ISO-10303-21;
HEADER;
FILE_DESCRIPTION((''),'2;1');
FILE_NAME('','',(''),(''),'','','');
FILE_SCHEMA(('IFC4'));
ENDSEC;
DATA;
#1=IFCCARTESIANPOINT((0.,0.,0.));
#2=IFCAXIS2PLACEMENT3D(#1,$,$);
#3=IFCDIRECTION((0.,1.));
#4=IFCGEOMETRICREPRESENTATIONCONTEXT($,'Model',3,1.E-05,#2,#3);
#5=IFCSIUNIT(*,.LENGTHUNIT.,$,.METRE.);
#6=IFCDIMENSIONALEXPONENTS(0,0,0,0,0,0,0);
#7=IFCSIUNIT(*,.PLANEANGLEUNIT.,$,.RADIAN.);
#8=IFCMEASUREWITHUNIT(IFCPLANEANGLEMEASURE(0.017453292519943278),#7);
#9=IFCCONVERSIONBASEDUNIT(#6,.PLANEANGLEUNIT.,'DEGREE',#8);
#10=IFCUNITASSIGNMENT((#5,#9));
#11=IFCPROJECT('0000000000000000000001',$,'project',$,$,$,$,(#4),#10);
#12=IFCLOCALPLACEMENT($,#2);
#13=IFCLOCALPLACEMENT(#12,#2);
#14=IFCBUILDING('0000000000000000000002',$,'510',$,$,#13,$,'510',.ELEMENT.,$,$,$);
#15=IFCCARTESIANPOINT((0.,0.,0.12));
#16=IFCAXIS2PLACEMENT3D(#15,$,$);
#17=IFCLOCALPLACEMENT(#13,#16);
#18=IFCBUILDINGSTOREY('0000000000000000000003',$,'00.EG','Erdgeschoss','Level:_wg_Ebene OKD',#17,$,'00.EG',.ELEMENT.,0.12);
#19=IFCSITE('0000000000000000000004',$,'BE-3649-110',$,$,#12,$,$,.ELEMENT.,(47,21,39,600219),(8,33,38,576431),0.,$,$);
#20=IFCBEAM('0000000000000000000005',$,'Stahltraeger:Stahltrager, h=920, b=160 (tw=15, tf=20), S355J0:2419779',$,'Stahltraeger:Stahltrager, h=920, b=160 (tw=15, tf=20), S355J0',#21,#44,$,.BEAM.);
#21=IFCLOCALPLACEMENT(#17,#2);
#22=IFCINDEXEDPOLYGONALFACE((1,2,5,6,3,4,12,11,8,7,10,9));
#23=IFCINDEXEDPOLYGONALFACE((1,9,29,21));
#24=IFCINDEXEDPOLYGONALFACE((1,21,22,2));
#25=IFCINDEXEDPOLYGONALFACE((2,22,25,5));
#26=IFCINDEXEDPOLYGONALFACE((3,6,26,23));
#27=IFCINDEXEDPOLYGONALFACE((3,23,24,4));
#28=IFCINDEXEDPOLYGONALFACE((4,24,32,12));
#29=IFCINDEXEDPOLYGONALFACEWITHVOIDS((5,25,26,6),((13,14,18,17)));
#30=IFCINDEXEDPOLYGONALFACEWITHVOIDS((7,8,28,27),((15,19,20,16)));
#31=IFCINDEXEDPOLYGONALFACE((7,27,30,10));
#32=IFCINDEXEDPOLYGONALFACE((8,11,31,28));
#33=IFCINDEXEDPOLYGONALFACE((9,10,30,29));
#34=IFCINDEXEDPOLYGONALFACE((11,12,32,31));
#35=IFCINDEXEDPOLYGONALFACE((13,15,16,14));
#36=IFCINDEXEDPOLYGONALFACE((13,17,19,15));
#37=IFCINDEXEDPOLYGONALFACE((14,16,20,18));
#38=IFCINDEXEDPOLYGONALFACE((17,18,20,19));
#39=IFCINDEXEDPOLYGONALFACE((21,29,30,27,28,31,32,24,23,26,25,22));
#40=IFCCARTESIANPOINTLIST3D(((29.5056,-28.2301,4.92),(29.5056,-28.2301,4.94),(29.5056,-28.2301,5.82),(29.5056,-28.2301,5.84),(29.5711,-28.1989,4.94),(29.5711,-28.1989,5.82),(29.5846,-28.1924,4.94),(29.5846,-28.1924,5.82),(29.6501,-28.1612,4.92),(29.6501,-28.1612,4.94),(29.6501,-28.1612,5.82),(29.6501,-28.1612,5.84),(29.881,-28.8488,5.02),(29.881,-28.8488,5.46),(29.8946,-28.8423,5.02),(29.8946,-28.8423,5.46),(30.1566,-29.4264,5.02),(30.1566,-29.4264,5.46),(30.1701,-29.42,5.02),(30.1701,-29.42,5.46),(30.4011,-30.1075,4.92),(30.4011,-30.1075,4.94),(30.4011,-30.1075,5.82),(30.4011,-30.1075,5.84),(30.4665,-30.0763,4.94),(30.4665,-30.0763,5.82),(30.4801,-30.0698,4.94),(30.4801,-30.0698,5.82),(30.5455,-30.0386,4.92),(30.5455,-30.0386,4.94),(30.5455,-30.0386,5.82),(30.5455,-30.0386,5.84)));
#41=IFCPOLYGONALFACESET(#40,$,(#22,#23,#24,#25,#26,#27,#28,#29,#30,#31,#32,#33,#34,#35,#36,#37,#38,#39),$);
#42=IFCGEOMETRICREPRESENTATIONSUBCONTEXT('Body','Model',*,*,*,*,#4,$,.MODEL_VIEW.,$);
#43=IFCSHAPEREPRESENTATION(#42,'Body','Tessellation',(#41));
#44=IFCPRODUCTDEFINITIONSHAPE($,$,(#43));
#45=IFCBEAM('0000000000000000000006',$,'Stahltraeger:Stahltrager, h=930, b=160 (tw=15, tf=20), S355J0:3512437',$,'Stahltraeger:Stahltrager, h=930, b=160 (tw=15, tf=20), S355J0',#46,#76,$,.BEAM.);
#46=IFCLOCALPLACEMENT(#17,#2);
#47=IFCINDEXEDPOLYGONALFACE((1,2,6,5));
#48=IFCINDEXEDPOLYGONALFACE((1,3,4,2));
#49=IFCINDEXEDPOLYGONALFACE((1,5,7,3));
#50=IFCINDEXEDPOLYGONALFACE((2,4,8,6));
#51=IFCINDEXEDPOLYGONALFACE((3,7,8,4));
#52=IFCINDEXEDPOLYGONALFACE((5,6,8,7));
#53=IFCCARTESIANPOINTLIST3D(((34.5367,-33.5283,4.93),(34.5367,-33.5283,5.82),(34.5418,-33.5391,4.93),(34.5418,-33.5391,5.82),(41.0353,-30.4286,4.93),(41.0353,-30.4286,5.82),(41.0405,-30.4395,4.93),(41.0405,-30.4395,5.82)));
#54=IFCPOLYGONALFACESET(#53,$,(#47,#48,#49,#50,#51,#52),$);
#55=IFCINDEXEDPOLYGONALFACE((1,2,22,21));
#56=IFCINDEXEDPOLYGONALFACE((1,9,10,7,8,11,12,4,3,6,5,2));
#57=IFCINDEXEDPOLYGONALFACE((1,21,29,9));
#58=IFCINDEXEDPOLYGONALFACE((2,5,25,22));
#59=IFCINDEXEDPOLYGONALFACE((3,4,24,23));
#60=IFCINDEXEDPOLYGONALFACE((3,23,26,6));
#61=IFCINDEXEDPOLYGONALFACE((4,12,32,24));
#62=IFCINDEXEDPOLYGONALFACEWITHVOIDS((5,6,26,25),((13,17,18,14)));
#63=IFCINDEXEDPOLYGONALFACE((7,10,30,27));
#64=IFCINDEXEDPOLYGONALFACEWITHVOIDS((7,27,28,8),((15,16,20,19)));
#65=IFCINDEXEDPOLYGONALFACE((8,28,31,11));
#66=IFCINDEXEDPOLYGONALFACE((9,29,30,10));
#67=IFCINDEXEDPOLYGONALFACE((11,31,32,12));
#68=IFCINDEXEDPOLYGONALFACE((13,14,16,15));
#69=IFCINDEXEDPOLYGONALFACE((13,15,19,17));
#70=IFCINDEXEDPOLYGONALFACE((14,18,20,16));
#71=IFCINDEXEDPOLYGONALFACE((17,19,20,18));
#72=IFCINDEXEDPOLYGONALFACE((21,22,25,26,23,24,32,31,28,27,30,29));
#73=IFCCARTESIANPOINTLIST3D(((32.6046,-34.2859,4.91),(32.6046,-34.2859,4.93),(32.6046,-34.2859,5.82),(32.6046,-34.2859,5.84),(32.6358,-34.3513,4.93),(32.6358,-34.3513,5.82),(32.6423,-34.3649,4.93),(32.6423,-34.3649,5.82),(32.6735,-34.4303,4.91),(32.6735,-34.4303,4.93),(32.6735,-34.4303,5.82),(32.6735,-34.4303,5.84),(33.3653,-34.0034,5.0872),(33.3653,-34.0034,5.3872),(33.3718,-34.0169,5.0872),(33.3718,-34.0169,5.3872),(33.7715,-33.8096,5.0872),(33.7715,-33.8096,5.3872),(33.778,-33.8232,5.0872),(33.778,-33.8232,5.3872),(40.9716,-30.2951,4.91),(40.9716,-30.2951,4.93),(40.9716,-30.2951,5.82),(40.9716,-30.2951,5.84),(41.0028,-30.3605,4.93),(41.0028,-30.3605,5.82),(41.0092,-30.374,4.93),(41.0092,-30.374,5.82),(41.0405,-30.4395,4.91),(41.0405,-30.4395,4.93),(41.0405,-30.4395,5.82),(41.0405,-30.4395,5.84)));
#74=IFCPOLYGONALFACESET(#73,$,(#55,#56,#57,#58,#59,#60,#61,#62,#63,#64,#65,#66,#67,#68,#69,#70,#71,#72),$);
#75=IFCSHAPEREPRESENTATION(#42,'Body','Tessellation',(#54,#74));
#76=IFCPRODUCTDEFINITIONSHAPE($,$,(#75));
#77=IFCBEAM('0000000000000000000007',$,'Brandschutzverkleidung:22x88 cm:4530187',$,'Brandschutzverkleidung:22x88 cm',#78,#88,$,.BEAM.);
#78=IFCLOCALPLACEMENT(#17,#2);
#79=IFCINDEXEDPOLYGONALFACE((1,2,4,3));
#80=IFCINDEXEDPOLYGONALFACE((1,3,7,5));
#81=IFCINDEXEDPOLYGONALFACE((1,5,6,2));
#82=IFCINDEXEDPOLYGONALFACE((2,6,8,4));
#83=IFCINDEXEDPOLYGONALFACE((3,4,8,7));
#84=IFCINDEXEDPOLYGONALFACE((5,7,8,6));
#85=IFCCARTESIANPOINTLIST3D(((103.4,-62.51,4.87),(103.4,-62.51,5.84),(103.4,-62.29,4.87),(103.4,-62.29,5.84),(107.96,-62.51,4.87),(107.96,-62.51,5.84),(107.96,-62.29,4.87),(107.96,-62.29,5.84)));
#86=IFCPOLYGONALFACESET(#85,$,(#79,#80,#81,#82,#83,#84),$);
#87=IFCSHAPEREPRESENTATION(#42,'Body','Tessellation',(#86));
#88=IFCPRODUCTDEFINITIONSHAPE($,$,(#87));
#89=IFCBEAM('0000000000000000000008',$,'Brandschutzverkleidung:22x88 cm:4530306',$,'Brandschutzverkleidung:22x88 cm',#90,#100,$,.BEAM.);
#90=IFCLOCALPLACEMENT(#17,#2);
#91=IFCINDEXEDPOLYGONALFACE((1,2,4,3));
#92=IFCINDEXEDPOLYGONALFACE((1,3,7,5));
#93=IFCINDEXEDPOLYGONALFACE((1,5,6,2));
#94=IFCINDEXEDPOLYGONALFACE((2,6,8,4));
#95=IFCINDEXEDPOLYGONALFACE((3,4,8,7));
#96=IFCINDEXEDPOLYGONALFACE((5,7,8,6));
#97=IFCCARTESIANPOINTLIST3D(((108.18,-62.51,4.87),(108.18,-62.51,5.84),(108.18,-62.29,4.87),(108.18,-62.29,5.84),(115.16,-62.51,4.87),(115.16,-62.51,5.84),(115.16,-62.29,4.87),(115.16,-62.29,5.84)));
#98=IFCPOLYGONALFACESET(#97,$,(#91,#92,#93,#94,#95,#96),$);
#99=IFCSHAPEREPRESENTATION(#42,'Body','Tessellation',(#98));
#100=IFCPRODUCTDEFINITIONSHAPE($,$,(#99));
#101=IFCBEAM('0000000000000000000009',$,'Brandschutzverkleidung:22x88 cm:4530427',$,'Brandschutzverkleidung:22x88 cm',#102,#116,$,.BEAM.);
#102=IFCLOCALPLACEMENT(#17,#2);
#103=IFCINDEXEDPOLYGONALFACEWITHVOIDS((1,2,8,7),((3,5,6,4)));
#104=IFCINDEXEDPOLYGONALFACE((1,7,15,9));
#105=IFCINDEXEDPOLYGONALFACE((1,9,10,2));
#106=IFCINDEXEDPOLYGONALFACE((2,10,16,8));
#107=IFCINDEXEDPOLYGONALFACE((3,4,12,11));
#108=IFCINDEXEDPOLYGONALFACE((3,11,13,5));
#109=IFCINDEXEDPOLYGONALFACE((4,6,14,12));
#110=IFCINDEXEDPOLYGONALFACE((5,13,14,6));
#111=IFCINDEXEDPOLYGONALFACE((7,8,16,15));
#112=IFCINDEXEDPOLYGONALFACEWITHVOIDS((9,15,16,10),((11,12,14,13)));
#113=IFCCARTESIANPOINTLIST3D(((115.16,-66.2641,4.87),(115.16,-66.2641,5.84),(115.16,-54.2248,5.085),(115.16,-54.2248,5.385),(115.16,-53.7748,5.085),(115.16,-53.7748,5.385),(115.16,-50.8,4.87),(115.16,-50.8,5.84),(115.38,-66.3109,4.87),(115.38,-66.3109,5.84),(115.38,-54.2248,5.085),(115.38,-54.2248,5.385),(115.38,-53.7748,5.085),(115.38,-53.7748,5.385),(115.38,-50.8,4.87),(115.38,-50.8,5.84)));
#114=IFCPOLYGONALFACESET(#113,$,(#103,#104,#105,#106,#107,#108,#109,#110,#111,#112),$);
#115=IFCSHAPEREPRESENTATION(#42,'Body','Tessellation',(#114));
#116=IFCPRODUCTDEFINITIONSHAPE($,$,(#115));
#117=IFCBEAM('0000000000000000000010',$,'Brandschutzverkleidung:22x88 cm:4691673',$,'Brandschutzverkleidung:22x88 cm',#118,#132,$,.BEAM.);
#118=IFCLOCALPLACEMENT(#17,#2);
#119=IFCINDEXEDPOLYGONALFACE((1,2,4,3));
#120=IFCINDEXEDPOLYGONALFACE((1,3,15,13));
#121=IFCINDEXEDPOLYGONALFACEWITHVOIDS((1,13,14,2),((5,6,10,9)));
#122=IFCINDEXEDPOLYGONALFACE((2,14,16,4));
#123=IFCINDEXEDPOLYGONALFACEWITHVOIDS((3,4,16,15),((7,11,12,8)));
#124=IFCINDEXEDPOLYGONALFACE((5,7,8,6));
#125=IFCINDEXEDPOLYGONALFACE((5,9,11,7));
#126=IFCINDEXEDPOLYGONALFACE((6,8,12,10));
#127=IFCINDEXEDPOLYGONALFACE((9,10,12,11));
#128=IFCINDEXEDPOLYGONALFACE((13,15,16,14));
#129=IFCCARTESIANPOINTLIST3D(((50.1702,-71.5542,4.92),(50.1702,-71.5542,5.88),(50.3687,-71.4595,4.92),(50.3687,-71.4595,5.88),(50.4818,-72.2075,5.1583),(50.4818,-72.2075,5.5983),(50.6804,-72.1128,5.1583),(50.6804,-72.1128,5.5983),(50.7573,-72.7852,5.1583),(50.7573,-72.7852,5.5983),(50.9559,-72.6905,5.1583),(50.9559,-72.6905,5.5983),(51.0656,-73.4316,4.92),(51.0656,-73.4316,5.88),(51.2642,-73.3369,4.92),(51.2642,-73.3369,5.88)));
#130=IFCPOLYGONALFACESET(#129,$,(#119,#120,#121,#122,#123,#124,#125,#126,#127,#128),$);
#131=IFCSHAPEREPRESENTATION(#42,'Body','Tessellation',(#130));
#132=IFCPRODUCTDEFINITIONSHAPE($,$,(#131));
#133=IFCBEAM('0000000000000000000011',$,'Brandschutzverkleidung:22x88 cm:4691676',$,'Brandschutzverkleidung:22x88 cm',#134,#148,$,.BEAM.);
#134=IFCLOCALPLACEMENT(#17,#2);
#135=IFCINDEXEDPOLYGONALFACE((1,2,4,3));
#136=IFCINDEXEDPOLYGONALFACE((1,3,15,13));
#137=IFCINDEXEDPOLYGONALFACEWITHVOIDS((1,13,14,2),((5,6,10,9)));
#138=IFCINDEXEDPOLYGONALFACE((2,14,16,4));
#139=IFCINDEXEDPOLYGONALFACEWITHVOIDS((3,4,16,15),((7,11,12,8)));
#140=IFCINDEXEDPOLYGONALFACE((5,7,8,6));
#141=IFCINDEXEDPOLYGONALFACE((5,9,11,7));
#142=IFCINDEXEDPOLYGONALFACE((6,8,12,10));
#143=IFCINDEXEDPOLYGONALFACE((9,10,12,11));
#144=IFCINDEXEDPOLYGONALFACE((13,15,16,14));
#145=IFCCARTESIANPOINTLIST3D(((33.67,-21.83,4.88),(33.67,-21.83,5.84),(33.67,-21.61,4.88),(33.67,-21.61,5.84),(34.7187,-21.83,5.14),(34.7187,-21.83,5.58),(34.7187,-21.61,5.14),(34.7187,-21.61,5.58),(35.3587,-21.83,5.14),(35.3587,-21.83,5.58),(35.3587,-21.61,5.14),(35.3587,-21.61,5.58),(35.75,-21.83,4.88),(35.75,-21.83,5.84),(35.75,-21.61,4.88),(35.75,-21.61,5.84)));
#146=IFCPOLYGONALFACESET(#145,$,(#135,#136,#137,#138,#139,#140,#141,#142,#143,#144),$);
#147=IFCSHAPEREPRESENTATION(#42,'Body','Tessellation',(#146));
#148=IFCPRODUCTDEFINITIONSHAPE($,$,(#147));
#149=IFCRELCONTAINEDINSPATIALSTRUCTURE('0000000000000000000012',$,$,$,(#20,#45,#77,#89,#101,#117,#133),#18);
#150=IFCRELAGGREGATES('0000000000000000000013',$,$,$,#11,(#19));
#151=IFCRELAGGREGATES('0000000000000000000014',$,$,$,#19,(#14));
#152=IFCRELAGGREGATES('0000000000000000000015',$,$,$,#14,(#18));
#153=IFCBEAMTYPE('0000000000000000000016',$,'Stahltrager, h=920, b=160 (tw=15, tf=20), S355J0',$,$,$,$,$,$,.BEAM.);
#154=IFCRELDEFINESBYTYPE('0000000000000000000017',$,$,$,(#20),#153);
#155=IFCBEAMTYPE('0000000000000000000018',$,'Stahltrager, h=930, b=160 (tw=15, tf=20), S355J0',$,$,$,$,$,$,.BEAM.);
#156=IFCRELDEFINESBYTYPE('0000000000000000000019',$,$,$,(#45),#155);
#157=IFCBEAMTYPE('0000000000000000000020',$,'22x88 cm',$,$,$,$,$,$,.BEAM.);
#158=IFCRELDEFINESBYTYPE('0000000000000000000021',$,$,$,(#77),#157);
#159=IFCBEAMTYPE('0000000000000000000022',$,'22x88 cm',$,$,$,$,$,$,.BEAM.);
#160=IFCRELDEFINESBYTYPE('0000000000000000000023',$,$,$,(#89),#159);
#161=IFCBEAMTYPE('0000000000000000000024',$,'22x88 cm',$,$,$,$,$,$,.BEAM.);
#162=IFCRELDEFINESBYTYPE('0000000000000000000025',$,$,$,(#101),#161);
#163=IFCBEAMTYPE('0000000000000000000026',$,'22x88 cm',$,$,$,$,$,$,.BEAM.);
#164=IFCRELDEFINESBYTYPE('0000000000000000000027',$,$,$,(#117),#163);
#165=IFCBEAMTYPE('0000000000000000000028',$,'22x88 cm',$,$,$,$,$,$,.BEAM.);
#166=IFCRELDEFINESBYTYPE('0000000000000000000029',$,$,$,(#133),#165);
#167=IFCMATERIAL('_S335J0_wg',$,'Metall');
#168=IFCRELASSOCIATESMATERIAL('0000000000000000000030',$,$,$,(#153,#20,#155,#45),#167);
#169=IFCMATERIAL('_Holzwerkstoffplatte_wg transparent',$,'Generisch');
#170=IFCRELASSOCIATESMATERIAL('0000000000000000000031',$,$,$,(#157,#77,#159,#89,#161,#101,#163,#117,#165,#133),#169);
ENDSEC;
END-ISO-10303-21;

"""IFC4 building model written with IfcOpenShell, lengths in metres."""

from ifc_helpers import new_model, entity, si_unit, converted_unit, direction, frame, origin, place, context, subcontext, project, spatial, indexed_curve, outline, extrude, source, transform, mapped, material, type_object, type_shapes, element, save


model = new_model("IFC4")

# Units and contexts
model_context = context("Model", 3, precision=1e-05, world=origin(), true_north=direction((0.0, 1.0)))
body_context = subcontext(model_context, "Body", "Model", "MODEL_VIEW")
ifc_project = project(units=[si_unit("LENGTHUNIT", "METRE"), converted_unit("PLANEANGLEUNIT", "DEGREE", entity("IfcPlaneAngleMeasure", 0.017453292519943278), si_unit("PLANEANGLEUNIT", "RADIAN"), dimensions=[0, 0, 0, 0, 0, 0, 0])], contexts=[model_context])

# Site, building, storey
site_placement = place(None, origin())
site = spatial("IfcSite", under=ifc_project, at=site_placement, Name="BE-3649-110", CompositionType="ELEMENT", RefLatitude=(47, 21, 39, 600219), RefLongitude=(8, 33, 38, 576431), RefElevation=0.0)
building_placement = place(site_placement, origin())
building = spatial("IfcBuilding", under=site, at=building_placement, Name="510", LongName="510", CompositionType="ELEMENT")
storey_placement = place(building_placement, frame((0.0, 0.0, 0.12)))
storey = spatial("IfcBuildingStorey", under=building, at=storey_placement, Name="00.EG", Description="Erdgeschoss", ObjectType="Level:_wg_Ebene OKD", LongName="00.EG", CompositionType="ELEMENT", Elevation=0.12)

# Beams, openings
ifc_material_1 = material(Name="_S335J0_wg", Category="Metall")
beam_type_1 = type_object("IfcBeamType", Name="Stahltrager, h=920, b=160 (tw=15, tf=20), S355J0", PredefinedType="BEAM", material=ifc_material_1)
shared_shape_1 = source(origin(), body_context, "Body", "SweptSolid", [
    extrude(outline(indexed_curve([(-0.08, -0.44), (-0.08, -0.46), (0.08, -0.46), (0.08, -0.44), (0.0075, -0.44), (0.0075, 0.44), (0.08, 0.44), (0.08, 0.46), (-0.08, 0.46), (-0.08, 0.44), (-0.0075, 0.44), (-0.0075, -0.44), (-0.08, -0.44)], self_intersect=False)), frame((0.9677, 0.0344, 0.46), z_axis=(0.430511, -0.902585, 0.0), x_axis=(0.902585, 0.430511, 0.0)), (0.0, 0.0, -1.0), 2.08),
])
type_shapes(beam_type_1, [shared_shape_1])
beam_1_placement = place(storey_placement, frame((29.5056, -30.1075, 4.92)))
beam_1 = element("IfcBeam", 1, at=beam_1_placement, inside=storey, type_object=beam_type_1, material=ifc_material_1, Name="Stahltraeger:Stahltrager, h=920, b=160 (tw=15, tf=20), S355J0:2419779", ObjectType="Stahltraeger:Stahltrager, h=920, b=160 (tw=15, tf=20), S355J0", PredefinedType="BEAM", context=body_context, shape_type="MappedRepresentation", body=[
    mapped(shared_shape_1, transform((0.0, 0.0, 0.0), scale=1.0)),
])
opening_1_placement = place(storey_placement, frame((29.5056, -30.1075, 4.92)))
element("IfcOpeningElement", 2, at=opening_1_placement, cuts=beam_1, PredefinedType="OPENING", context=body_context, shape_type="SweptSolid", body=[
    extrude(outline(indexed_curve([(-0.32, -0.22), (0.32, -0.22), (0.32, 0.22), (-0.32, 0.22), (-0.32, -0.22)], self_intersect=False)), frame((0.5267, 0.9764, 0.32), z_axis=(-0.902585, -0.430511, 0.0), x_axis=(0.430511, -0.902585, 0.0)), (0.0, 0.0, 1.0), 0.015),
])
beam_type_2 = type_object("IfcBeamType", Name="Stahltrager, h=930, b=160 (tw=15, tf=20), S355J0", PredefinedType="BEAM", material=ifc_material_1)
shared_shape_2 = source(origin(), body_context, "Body", "SweptSolid", [
    extrude(outline(indexed_curve([(-0.006, -0.445), (0.006, -0.445), (0.006, 0.445), (-0.006, 0.445), (-0.006, -0.445)], self_intersect=False)), frame((1.9347, 0.8966, 0.465), z_axis=(0.902585, 0.430511, 0.0), x_axis=(0.430511, -0.902585, 0.0)), (0.0, 0.0, 1.0), 7.2),
    extrude(outline(indexed_curve([(-0.08, -0.445), (-0.08, -0.465), (0.08, -0.465), (0.08, -0.445), (0.0075, -0.445), (0.0075, 0.445), (0.08, 0.445), (0.08, 0.465), (-0.08, 0.465), (-0.08, 0.445), (-0.0075, 0.445), (-0.0075, -0.445), (-0.08, -0.445)], self_intersect=False)), frame((0.0344, 0.0722, 0.465), z_axis=(-0.902585, -0.430511, 0.0), x_axis=(0.430511, -0.902585, 0.0)), (0.0, 0.0, -1.0), 9.27),
])
type_shapes(beam_type_2, [shared_shape_2])
beam_2_placement = place(storey_placement, frame((32.6046, -34.4303, 4.91)))
beam_2 = element("IfcBeam", 3, at=beam_2_placement, inside=storey, type_object=beam_type_2, material=ifc_material_1, Name="Stahltraeger:Stahltrager, h=930, b=160 (tw=15, tf=20), S355J0:3512437", ObjectType="Stahltraeger:Stahltrager, h=930, b=160 (tw=15, tf=20), S355J0", PredefinedType="BEAM", context=body_context, shape_type="MappedRepresentation", body=[
    mapped(shared_shape_2, transform((0.0, 0.0, 0.0), scale=1.0)),
])
opening_2_placement = place(storey_placement, frame((32.6046, -34.4303, 4.91)))
element("IfcOpeningElement", 4, at=opening_2_placement, cuts=beam_2, PredefinedType="OPENING", context=body_context, shape_type="SweptSolid", body=[
    extrude(outline(indexed_curve([(-0.225, -0.15), (0.225, -0.15), (0.225, 0.15), (-0.225, 0.15), (-0.225, -0.15)], self_intersect=False)), frame((0.9638, 0.5238, 0.3272), z_axis=(0.430511, -0.902585, 0.0), x_axis=(0.902585, 0.430511, 0.0)), (0.0, 0.0, 1.0), 0.015),
])

# Beams
ifc_material_2 = material(Name="_Holzwerkstoffplatte_wg transparent", Category="Generisch")
beam_type_3 = type_object("IfcBeamType", Name="22x88 cm", PredefinedType="BEAM", material=ifc_material_2)
shared_shape_3 = source(origin(), body_context, "Body", "SweptSolid", [
    extrude(outline(indexed_curve([(-2.28, -0.11), (2.28, -0.11), (2.28, 0.11), (-2.28, 0.11), (-2.28, -0.11)], self_intersect=False)), frame((105.68, -62.4, -0.485)), (0.0, 0.0, 1.0), 0.97),
])
type_shapes(beam_type_3, [shared_shape_3])
beam_3_placement = place(storey_placement, frame((0.0, 0.0, 5.355)))
element("IfcBeam", 5, at=beam_3_placement, inside=storey, type_object=beam_type_3, material=ifc_material_2, Name="Brandschutzverkleidung:22x88 cm:4530187", ObjectType="Brandschutzverkleidung:22x88 cm", PredefinedType="BEAM", context=body_context, shape_type="MappedRepresentation", body=[
    mapped(shared_shape_3, transform((0.0, 0.0, 0.0), scale=1.0)),
])
beam_type_4 = type_object("IfcBeamType", Name="22x88 cm", PredefinedType="BEAM", material=ifc_material_2)
shared_shape_4 = source(origin(), body_context, "Body", "SweptSolid", [
    extrude(outline(indexed_curve([(-3.49, -0.11), (3.49, -0.11), (3.49, 0.11), (-3.49, 0.11), (-3.49, -0.11)], self_intersect=False)), frame((111.67, -62.4, -0.485)), (0.0, 0.0, 1.0), 0.97),
])
type_shapes(beam_type_4, [shared_shape_4])
beam_4_placement = place(storey_placement, frame((0.0, 0.0, 5.355)))
element("IfcBeam", 6, at=beam_4_placement, inside=storey, type_object=beam_type_4, material=ifc_material_2, Name="Brandschutzverkleidung:22x88 cm:4530306", ObjectType="Brandschutzverkleidung:22x88 cm", PredefinedType="BEAM", context=body_context, shape_type="MappedRepresentation", body=[
    mapped(shared_shape_4, transform((0.0, 0.0, 0.0), scale=1.0)),
])

# Beam, opening
beam_type_5 = type_object("IfcBeamType", Name="22x88 cm", PredefinedType="BEAM", material=ifc_material_2)
shared_shape_5 = source(origin(), body_context, "Body", "SweptSolid", [
    extrude(outline(indexed_curve([(-7.7437, -0.11), (7.7203, -0.11), (7.7671, 0.11), (-7.7437, 0.11), (-7.7437, -0.11)], self_intersect=False)), frame((115.27, -58.5437, -0.485), z_axis=(0.0, 0.0, 1.0), x_axis=(0.0, -1.0, 0.0)), (0.0, 0.0, 1.0), 0.97),
])
type_shapes(beam_type_5, [shared_shape_5])
beam_5_placement = place(storey_placement, frame((0.0, 0.0, 5.355)))
beam_5 = element("IfcBeam", 7, at=beam_5_placement, inside=storey, type_object=beam_type_5, material=ifc_material_2, Name="Brandschutzverkleidung:22x88 cm:4530427", ObjectType="Brandschutzverkleidung:22x88 cm", PredefinedType="BEAM", context=body_context, shape_type="MappedRepresentation", body=[
    mapped(shared_shape_5, transform((0.0, 0.0, 0.0), scale=1.0)),
])
opening_3_placement = place(storey_placement, frame((0.0, 0.0, 5.355)))
element("IfcOpeningElement", 8, at=opening_3_placement, cuts=beam_5, PredefinedType="OPENING", context=body_context, shape_type="SweptSolid", body=[
    extrude(outline(indexed_curve([(-0.225, -0.15), (0.225, -0.15), (0.225, 0.15), (-0.225, 0.15), (-0.225, -0.15)], self_intersect=False)), frame((115.38, -53.9998, -0.12), z_axis=(-1.0, 0.0, 0.0), x_axis=(0.0, 1.0, 0.0)), (0.0, 0.0, 1.0), 0.22),
])

# Beams
beam_type_6 = type_object("IfcBeamType", Name="22x88 cm", PredefinedType="BEAM", material=ifc_material_2)
shared_shape_6 = source(origin(), body_context, "Body", "SweptSolid", [
    extrude(outline(indexed_curve([(-1.04, -0.48), (1.04, -0.48), (1.04, 0.48), (-1.04, 0.48), (-1.04, -0.48)], self_intersect=False), holes=[indexed_curve([(0.3238, 0.2417), (0.3238, -0.1983), (-0.3162, -0.1983), (-0.3162, 0.2417), (0.3238, 0.2417)], self_intersect=False)]), frame((50.6179, -72.4929, 0.0), z_axis=(0.902585, 0.430511, 0.0), x_axis=(0.430511, -0.902585, 0.0)), (0.0, 0.0, 1.0), 0.22),
])
type_shapes(beam_type_6, [shared_shape_6])
beam_6_placement = place(storey_placement, frame((0.0, 0.0, 5.4)))
element("IfcBeam", 9, at=beam_6_placement, inside=storey, type_object=beam_type_6, material=ifc_material_2, Name="Brandschutzverkleidung:22x88 cm:4691673", ObjectType="Brandschutzverkleidung:22x88 cm", PredefinedType="BEAM", context=body_context, shape_type="MappedRepresentation", body=[
    mapped(shared_shape_6, transform((0.0, 0.0, 0.0), scale=1.0)),
])
beam_type_7 = type_object("IfcBeamType", Name="22x88 cm", PredefinedType="BEAM", material=ifc_material_2)
shared_shape_7 = source(origin(), body_context, "Body", "SweptSolid", [
    extrude(outline(indexed_curve([(-1.04, -0.48), (1.04, -0.48), (1.04, 0.48), (-1.04, 0.48), (-1.04, -0.48)], self_intersect=False), holes=[indexed_curve([(0.6487, 0.22), (0.6487, -0.22), (0.0087, -0.22), (0.0087, 0.22), (0.6487, 0.22)], self_intersect=False)]), frame((34.71, -21.83, 0.0), z_axis=(0.0, 1.0, 0.0), x_axis=(1.0, 0.0, 0.0)), (0.0, 0.0, 1.0), 0.22),
])
type_shapes(beam_type_7, [shared_shape_7])
beam_7_placement = place(storey_placement, frame((0.0, 0.0, 5.36)))
element("IfcBeam", 10, at=beam_7_placement, inside=storey, type_object=beam_type_7, material=ifc_material_2, Name="Brandschutzverkleidung:22x88 cm:4691676", ObjectType="Brandschutzverkleidung:22x88 cm", PredefinedType="BEAM", context=body_context, shape_type="MappedRepresentation", body=[
    mapped(shared_shape_7, transform((0.0, 0.0, 0.0), scale=1.0)),
])

save(model, "model.ifc")
